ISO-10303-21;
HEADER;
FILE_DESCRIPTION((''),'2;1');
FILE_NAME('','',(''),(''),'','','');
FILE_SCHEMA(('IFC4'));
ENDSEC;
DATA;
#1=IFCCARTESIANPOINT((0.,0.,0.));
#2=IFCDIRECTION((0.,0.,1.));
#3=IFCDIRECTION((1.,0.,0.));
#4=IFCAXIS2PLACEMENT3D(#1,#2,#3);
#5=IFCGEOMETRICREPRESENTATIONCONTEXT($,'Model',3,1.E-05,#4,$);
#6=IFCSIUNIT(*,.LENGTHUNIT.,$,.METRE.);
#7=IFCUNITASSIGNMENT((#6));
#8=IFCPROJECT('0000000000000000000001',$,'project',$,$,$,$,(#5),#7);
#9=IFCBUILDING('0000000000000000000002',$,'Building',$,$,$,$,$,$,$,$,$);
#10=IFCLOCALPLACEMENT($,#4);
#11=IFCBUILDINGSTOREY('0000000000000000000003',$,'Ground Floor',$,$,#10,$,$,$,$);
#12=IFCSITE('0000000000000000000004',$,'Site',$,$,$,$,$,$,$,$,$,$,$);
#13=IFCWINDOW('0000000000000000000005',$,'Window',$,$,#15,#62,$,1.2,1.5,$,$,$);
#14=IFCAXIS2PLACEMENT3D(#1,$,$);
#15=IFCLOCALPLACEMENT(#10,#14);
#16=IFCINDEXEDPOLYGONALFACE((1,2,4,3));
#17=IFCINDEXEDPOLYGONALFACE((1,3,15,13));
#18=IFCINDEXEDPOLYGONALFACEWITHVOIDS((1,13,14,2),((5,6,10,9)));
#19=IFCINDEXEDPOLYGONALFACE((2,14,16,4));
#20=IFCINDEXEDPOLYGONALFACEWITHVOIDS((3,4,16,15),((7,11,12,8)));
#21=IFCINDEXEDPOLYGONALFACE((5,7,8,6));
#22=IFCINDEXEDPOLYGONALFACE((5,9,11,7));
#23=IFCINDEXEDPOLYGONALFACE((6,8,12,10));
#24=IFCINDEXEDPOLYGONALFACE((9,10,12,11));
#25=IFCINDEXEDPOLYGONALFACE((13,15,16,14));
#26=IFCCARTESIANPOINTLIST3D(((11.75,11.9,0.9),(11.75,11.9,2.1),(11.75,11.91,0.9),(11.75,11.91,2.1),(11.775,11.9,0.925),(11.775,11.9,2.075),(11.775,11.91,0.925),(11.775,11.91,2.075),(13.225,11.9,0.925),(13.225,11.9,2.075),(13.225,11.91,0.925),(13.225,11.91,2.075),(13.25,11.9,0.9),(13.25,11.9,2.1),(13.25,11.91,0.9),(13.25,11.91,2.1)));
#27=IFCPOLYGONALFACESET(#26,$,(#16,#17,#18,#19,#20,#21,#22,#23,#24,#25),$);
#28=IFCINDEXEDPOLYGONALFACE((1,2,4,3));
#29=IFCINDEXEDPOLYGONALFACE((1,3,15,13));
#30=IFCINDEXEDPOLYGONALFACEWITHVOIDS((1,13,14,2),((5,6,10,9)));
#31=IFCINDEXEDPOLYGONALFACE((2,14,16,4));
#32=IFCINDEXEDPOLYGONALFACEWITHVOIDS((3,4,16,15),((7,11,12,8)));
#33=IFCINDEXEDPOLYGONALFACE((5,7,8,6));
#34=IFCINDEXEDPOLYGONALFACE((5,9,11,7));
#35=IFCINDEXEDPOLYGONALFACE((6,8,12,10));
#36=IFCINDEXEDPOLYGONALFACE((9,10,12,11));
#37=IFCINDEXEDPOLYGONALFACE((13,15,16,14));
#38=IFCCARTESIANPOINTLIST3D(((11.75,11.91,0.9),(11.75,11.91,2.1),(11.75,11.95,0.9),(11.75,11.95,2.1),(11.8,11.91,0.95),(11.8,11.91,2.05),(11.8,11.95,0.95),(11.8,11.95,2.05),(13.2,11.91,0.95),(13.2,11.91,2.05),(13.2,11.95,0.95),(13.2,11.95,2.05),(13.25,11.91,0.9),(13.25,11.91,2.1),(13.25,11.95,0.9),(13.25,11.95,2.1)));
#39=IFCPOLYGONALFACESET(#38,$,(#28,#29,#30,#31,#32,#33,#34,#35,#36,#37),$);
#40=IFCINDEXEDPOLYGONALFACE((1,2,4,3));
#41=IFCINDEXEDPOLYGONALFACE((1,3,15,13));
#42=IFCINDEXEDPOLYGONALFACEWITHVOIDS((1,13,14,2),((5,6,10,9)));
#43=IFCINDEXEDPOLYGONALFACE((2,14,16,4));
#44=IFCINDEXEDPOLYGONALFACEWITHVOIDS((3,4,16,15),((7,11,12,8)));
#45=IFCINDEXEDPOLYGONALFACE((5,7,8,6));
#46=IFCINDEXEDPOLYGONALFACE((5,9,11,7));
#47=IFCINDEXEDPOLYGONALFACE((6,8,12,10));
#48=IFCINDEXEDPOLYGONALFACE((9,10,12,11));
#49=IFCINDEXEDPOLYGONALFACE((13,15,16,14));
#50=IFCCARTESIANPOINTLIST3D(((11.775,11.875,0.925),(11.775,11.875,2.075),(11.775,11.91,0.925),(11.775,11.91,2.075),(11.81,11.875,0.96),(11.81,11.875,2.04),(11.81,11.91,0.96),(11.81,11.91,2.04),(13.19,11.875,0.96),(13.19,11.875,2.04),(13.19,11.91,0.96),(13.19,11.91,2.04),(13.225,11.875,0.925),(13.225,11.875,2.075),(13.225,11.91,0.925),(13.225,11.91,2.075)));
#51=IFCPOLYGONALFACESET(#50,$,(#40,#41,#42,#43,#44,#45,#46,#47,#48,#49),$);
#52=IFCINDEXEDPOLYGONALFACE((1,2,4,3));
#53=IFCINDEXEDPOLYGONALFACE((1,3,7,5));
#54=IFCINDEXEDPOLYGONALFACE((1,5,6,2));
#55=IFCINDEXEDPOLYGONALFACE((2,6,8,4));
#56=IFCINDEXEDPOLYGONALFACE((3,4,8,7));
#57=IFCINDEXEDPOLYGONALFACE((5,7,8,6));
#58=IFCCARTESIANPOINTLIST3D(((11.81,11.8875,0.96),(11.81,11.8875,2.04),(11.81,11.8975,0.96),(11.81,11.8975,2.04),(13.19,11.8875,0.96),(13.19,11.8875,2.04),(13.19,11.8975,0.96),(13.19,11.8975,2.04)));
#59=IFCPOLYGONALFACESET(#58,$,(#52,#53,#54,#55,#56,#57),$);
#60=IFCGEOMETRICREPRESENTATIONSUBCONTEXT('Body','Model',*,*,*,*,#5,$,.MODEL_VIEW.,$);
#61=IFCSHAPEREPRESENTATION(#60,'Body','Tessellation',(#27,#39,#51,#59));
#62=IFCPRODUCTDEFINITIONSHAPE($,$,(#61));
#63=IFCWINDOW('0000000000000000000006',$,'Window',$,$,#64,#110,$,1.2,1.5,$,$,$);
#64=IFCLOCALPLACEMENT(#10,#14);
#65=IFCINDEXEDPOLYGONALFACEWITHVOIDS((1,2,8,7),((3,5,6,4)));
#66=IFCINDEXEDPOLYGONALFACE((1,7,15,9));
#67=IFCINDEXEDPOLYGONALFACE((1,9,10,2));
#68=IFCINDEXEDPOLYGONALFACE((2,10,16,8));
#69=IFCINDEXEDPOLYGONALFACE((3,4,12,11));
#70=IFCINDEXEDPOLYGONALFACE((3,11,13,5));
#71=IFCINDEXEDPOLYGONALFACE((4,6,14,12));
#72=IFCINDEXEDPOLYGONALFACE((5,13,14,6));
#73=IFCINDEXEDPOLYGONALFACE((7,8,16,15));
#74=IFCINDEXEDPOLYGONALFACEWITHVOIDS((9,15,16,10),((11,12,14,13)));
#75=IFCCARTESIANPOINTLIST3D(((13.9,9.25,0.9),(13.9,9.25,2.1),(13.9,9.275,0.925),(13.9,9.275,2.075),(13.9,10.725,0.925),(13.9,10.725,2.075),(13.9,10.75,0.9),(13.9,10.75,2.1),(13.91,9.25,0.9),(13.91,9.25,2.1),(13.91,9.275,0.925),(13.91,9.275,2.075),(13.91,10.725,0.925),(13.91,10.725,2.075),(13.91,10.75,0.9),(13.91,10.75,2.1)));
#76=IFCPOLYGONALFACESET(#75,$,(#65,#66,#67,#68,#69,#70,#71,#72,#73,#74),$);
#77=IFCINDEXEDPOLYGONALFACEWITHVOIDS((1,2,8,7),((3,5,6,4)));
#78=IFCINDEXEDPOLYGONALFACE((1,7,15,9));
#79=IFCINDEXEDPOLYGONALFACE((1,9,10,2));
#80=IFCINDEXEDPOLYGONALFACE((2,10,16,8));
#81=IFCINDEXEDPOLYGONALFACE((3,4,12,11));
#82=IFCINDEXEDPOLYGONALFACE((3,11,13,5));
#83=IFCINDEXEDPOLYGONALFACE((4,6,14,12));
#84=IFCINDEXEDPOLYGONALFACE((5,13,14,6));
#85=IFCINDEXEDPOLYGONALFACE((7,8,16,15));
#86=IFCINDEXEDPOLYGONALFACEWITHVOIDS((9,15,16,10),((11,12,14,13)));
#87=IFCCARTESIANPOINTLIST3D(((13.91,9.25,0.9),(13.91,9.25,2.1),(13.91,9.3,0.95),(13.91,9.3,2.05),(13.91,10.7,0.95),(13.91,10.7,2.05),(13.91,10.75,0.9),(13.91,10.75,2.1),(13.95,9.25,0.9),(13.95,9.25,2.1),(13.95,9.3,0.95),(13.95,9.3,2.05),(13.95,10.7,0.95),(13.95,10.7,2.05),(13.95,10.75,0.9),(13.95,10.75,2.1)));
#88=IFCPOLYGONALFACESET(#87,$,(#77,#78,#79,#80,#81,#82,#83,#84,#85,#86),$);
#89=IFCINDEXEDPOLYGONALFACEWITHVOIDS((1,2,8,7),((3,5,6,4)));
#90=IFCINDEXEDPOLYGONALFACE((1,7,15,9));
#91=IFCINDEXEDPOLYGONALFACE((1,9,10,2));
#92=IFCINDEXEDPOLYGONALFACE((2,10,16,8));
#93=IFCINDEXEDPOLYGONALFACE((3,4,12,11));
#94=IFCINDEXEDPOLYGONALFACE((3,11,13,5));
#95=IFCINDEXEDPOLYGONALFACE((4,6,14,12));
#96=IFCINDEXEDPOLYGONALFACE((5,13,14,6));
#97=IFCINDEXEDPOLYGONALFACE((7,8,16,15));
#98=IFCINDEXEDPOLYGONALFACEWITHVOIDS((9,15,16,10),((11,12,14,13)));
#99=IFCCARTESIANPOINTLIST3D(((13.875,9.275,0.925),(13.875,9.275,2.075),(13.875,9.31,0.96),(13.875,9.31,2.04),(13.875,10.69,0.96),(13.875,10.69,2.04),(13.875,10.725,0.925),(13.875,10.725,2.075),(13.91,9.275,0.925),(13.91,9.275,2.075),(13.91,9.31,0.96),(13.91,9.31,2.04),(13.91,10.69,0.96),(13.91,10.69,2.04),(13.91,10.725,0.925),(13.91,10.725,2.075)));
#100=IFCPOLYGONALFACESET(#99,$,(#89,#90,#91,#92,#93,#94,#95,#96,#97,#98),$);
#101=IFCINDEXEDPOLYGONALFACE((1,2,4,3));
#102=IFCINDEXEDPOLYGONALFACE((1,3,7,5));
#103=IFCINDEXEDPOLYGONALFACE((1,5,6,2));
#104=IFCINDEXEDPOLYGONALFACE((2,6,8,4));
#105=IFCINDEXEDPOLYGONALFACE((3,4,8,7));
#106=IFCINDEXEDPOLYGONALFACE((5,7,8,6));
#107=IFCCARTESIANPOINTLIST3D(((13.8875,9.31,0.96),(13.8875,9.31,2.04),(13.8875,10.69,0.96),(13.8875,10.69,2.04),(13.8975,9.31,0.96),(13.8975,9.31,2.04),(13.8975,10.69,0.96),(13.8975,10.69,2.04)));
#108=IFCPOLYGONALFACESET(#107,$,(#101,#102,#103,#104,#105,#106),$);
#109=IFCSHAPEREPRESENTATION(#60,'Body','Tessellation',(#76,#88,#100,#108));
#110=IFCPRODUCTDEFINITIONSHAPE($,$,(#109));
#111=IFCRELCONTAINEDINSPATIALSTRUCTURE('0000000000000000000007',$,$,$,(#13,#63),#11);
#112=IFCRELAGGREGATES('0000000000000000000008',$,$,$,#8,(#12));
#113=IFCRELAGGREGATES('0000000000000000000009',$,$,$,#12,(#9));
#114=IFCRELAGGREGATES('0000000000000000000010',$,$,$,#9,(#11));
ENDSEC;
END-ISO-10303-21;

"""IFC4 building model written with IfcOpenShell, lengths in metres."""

from ifc_helpers import new_model, si_unit, frame, origin_with_axes, place, context, subcontext, project, spatial, line, indexed_curve, outline, extrude, element, save


model = new_model("IFC4")

# Units and contexts
model_context = context("Model", 3, precision=1e-05, world=origin_with_axes())
body_context = subcontext(model_context, "Body", "Model", "MODEL_VIEW")
ifc_project = project(units=[si_unit("LENGTHUNIT", "METRE")], contexts=[model_context])

# Site, building, storey
site = spatial("IfcSite", under=ifc_project, Name="Site")
building = spatial("IfcBuilding", under=site, Name="Building")
storey_placement = place(None, origin_with_axes())
storey = spatial("IfcBuildingStorey", under=building, at=storey_placement, Name="Ground Floor")

# Windows
for number, where, z_axis, x_axis, name in (
    (1, (13.25, 12.0, 0.9), (0.0, 0.0, 1.0), (-1.0, 0.0, 0.0), "Window"),
    (2, (14.0, 9.25, 0.9), (0.0, 0.0, 1.0), (0.0, 1.0, 0.0), "Window"),
):
    element("IfcWindow", number, at=place(storey_placement, frame(where, z_axis=z_axis, x_axis=x_axis)), inside=storey, Name=name, OverallHeight=1.2, OverallWidth=1.5, context=body_context, shape_type="SweptSolid", body=[
        extrude(outline(indexed_curve([(0.0, 0.0), (1.5, 0.0), (1.5, 1.2), (0.0, 1.2)], segments=[line(1, 2, 3, 4, 1)]), holes=[indexed_curve([(0.025, 0.025), (1.475, 0.025), (1.475, 1.175), (0.025, 1.175)], segments=[line(1, 2, 3, 4, 1)])]), frame((0.0, 0.09, 0.0), z_axis=(0.0, -1.0, 0.0), x_axis=(1.0, 0.0, 0.0)), (0.0, 0.0, -1.0), 0.01),
        extrude(outline(indexed_curve([(0.0, 0.0), (1.5, 0.0), (1.5, 1.2), (0.0, 1.2)], segments=[line(1, 2, 3, 4, 1)]), holes=[indexed_curve([(0.05, 0.05), (1.45, 0.05), (1.45, 1.15), (0.05, 1.15)], segments=[line(1, 2, 3, 4, 1)])]), frame((0.0, 0.05, 0.0), z_axis=(0.0, -1.0, 0.0), x_axis=(1.0, 0.0, 0.0)), (0.0, 0.0, -1.0), 0.04),
        extrude(outline(indexed_curve([(0.0, 0.0), (1.45, 0.0), (1.45, 1.15), (0.0, 1.15)], segments=[line(1, 2, 3, 4, 1)]), holes=[indexed_curve([(0.035, 0.035), (1.415, 0.035), (1.415, 1.115), (0.035, 1.115)], segments=[line(1, 2, 3, 4, 1)])]), frame((0.025, 0.09, 0.025), z_axis=(0.0, -1.0, 0.0), x_axis=(1.0, 0.0, 0.0)), (0.0, 0.0, -1.0), 0.035),
        extrude(outline(indexed_curve([(0.035, 0.035), (1.415, 0.035), (1.415, 1.115), (0.035, 1.115)], segments=[line(1, 2, 3, 4, 1)])), frame((0.025, 0.1025, 0.025), z_axis=(0.0, -1.0, 0.0), x_axis=(1.0, 0.0, 0.0)), (0.0, 0.0, -1.0), 0.01),
    ])

save(model, "model.ifc")
